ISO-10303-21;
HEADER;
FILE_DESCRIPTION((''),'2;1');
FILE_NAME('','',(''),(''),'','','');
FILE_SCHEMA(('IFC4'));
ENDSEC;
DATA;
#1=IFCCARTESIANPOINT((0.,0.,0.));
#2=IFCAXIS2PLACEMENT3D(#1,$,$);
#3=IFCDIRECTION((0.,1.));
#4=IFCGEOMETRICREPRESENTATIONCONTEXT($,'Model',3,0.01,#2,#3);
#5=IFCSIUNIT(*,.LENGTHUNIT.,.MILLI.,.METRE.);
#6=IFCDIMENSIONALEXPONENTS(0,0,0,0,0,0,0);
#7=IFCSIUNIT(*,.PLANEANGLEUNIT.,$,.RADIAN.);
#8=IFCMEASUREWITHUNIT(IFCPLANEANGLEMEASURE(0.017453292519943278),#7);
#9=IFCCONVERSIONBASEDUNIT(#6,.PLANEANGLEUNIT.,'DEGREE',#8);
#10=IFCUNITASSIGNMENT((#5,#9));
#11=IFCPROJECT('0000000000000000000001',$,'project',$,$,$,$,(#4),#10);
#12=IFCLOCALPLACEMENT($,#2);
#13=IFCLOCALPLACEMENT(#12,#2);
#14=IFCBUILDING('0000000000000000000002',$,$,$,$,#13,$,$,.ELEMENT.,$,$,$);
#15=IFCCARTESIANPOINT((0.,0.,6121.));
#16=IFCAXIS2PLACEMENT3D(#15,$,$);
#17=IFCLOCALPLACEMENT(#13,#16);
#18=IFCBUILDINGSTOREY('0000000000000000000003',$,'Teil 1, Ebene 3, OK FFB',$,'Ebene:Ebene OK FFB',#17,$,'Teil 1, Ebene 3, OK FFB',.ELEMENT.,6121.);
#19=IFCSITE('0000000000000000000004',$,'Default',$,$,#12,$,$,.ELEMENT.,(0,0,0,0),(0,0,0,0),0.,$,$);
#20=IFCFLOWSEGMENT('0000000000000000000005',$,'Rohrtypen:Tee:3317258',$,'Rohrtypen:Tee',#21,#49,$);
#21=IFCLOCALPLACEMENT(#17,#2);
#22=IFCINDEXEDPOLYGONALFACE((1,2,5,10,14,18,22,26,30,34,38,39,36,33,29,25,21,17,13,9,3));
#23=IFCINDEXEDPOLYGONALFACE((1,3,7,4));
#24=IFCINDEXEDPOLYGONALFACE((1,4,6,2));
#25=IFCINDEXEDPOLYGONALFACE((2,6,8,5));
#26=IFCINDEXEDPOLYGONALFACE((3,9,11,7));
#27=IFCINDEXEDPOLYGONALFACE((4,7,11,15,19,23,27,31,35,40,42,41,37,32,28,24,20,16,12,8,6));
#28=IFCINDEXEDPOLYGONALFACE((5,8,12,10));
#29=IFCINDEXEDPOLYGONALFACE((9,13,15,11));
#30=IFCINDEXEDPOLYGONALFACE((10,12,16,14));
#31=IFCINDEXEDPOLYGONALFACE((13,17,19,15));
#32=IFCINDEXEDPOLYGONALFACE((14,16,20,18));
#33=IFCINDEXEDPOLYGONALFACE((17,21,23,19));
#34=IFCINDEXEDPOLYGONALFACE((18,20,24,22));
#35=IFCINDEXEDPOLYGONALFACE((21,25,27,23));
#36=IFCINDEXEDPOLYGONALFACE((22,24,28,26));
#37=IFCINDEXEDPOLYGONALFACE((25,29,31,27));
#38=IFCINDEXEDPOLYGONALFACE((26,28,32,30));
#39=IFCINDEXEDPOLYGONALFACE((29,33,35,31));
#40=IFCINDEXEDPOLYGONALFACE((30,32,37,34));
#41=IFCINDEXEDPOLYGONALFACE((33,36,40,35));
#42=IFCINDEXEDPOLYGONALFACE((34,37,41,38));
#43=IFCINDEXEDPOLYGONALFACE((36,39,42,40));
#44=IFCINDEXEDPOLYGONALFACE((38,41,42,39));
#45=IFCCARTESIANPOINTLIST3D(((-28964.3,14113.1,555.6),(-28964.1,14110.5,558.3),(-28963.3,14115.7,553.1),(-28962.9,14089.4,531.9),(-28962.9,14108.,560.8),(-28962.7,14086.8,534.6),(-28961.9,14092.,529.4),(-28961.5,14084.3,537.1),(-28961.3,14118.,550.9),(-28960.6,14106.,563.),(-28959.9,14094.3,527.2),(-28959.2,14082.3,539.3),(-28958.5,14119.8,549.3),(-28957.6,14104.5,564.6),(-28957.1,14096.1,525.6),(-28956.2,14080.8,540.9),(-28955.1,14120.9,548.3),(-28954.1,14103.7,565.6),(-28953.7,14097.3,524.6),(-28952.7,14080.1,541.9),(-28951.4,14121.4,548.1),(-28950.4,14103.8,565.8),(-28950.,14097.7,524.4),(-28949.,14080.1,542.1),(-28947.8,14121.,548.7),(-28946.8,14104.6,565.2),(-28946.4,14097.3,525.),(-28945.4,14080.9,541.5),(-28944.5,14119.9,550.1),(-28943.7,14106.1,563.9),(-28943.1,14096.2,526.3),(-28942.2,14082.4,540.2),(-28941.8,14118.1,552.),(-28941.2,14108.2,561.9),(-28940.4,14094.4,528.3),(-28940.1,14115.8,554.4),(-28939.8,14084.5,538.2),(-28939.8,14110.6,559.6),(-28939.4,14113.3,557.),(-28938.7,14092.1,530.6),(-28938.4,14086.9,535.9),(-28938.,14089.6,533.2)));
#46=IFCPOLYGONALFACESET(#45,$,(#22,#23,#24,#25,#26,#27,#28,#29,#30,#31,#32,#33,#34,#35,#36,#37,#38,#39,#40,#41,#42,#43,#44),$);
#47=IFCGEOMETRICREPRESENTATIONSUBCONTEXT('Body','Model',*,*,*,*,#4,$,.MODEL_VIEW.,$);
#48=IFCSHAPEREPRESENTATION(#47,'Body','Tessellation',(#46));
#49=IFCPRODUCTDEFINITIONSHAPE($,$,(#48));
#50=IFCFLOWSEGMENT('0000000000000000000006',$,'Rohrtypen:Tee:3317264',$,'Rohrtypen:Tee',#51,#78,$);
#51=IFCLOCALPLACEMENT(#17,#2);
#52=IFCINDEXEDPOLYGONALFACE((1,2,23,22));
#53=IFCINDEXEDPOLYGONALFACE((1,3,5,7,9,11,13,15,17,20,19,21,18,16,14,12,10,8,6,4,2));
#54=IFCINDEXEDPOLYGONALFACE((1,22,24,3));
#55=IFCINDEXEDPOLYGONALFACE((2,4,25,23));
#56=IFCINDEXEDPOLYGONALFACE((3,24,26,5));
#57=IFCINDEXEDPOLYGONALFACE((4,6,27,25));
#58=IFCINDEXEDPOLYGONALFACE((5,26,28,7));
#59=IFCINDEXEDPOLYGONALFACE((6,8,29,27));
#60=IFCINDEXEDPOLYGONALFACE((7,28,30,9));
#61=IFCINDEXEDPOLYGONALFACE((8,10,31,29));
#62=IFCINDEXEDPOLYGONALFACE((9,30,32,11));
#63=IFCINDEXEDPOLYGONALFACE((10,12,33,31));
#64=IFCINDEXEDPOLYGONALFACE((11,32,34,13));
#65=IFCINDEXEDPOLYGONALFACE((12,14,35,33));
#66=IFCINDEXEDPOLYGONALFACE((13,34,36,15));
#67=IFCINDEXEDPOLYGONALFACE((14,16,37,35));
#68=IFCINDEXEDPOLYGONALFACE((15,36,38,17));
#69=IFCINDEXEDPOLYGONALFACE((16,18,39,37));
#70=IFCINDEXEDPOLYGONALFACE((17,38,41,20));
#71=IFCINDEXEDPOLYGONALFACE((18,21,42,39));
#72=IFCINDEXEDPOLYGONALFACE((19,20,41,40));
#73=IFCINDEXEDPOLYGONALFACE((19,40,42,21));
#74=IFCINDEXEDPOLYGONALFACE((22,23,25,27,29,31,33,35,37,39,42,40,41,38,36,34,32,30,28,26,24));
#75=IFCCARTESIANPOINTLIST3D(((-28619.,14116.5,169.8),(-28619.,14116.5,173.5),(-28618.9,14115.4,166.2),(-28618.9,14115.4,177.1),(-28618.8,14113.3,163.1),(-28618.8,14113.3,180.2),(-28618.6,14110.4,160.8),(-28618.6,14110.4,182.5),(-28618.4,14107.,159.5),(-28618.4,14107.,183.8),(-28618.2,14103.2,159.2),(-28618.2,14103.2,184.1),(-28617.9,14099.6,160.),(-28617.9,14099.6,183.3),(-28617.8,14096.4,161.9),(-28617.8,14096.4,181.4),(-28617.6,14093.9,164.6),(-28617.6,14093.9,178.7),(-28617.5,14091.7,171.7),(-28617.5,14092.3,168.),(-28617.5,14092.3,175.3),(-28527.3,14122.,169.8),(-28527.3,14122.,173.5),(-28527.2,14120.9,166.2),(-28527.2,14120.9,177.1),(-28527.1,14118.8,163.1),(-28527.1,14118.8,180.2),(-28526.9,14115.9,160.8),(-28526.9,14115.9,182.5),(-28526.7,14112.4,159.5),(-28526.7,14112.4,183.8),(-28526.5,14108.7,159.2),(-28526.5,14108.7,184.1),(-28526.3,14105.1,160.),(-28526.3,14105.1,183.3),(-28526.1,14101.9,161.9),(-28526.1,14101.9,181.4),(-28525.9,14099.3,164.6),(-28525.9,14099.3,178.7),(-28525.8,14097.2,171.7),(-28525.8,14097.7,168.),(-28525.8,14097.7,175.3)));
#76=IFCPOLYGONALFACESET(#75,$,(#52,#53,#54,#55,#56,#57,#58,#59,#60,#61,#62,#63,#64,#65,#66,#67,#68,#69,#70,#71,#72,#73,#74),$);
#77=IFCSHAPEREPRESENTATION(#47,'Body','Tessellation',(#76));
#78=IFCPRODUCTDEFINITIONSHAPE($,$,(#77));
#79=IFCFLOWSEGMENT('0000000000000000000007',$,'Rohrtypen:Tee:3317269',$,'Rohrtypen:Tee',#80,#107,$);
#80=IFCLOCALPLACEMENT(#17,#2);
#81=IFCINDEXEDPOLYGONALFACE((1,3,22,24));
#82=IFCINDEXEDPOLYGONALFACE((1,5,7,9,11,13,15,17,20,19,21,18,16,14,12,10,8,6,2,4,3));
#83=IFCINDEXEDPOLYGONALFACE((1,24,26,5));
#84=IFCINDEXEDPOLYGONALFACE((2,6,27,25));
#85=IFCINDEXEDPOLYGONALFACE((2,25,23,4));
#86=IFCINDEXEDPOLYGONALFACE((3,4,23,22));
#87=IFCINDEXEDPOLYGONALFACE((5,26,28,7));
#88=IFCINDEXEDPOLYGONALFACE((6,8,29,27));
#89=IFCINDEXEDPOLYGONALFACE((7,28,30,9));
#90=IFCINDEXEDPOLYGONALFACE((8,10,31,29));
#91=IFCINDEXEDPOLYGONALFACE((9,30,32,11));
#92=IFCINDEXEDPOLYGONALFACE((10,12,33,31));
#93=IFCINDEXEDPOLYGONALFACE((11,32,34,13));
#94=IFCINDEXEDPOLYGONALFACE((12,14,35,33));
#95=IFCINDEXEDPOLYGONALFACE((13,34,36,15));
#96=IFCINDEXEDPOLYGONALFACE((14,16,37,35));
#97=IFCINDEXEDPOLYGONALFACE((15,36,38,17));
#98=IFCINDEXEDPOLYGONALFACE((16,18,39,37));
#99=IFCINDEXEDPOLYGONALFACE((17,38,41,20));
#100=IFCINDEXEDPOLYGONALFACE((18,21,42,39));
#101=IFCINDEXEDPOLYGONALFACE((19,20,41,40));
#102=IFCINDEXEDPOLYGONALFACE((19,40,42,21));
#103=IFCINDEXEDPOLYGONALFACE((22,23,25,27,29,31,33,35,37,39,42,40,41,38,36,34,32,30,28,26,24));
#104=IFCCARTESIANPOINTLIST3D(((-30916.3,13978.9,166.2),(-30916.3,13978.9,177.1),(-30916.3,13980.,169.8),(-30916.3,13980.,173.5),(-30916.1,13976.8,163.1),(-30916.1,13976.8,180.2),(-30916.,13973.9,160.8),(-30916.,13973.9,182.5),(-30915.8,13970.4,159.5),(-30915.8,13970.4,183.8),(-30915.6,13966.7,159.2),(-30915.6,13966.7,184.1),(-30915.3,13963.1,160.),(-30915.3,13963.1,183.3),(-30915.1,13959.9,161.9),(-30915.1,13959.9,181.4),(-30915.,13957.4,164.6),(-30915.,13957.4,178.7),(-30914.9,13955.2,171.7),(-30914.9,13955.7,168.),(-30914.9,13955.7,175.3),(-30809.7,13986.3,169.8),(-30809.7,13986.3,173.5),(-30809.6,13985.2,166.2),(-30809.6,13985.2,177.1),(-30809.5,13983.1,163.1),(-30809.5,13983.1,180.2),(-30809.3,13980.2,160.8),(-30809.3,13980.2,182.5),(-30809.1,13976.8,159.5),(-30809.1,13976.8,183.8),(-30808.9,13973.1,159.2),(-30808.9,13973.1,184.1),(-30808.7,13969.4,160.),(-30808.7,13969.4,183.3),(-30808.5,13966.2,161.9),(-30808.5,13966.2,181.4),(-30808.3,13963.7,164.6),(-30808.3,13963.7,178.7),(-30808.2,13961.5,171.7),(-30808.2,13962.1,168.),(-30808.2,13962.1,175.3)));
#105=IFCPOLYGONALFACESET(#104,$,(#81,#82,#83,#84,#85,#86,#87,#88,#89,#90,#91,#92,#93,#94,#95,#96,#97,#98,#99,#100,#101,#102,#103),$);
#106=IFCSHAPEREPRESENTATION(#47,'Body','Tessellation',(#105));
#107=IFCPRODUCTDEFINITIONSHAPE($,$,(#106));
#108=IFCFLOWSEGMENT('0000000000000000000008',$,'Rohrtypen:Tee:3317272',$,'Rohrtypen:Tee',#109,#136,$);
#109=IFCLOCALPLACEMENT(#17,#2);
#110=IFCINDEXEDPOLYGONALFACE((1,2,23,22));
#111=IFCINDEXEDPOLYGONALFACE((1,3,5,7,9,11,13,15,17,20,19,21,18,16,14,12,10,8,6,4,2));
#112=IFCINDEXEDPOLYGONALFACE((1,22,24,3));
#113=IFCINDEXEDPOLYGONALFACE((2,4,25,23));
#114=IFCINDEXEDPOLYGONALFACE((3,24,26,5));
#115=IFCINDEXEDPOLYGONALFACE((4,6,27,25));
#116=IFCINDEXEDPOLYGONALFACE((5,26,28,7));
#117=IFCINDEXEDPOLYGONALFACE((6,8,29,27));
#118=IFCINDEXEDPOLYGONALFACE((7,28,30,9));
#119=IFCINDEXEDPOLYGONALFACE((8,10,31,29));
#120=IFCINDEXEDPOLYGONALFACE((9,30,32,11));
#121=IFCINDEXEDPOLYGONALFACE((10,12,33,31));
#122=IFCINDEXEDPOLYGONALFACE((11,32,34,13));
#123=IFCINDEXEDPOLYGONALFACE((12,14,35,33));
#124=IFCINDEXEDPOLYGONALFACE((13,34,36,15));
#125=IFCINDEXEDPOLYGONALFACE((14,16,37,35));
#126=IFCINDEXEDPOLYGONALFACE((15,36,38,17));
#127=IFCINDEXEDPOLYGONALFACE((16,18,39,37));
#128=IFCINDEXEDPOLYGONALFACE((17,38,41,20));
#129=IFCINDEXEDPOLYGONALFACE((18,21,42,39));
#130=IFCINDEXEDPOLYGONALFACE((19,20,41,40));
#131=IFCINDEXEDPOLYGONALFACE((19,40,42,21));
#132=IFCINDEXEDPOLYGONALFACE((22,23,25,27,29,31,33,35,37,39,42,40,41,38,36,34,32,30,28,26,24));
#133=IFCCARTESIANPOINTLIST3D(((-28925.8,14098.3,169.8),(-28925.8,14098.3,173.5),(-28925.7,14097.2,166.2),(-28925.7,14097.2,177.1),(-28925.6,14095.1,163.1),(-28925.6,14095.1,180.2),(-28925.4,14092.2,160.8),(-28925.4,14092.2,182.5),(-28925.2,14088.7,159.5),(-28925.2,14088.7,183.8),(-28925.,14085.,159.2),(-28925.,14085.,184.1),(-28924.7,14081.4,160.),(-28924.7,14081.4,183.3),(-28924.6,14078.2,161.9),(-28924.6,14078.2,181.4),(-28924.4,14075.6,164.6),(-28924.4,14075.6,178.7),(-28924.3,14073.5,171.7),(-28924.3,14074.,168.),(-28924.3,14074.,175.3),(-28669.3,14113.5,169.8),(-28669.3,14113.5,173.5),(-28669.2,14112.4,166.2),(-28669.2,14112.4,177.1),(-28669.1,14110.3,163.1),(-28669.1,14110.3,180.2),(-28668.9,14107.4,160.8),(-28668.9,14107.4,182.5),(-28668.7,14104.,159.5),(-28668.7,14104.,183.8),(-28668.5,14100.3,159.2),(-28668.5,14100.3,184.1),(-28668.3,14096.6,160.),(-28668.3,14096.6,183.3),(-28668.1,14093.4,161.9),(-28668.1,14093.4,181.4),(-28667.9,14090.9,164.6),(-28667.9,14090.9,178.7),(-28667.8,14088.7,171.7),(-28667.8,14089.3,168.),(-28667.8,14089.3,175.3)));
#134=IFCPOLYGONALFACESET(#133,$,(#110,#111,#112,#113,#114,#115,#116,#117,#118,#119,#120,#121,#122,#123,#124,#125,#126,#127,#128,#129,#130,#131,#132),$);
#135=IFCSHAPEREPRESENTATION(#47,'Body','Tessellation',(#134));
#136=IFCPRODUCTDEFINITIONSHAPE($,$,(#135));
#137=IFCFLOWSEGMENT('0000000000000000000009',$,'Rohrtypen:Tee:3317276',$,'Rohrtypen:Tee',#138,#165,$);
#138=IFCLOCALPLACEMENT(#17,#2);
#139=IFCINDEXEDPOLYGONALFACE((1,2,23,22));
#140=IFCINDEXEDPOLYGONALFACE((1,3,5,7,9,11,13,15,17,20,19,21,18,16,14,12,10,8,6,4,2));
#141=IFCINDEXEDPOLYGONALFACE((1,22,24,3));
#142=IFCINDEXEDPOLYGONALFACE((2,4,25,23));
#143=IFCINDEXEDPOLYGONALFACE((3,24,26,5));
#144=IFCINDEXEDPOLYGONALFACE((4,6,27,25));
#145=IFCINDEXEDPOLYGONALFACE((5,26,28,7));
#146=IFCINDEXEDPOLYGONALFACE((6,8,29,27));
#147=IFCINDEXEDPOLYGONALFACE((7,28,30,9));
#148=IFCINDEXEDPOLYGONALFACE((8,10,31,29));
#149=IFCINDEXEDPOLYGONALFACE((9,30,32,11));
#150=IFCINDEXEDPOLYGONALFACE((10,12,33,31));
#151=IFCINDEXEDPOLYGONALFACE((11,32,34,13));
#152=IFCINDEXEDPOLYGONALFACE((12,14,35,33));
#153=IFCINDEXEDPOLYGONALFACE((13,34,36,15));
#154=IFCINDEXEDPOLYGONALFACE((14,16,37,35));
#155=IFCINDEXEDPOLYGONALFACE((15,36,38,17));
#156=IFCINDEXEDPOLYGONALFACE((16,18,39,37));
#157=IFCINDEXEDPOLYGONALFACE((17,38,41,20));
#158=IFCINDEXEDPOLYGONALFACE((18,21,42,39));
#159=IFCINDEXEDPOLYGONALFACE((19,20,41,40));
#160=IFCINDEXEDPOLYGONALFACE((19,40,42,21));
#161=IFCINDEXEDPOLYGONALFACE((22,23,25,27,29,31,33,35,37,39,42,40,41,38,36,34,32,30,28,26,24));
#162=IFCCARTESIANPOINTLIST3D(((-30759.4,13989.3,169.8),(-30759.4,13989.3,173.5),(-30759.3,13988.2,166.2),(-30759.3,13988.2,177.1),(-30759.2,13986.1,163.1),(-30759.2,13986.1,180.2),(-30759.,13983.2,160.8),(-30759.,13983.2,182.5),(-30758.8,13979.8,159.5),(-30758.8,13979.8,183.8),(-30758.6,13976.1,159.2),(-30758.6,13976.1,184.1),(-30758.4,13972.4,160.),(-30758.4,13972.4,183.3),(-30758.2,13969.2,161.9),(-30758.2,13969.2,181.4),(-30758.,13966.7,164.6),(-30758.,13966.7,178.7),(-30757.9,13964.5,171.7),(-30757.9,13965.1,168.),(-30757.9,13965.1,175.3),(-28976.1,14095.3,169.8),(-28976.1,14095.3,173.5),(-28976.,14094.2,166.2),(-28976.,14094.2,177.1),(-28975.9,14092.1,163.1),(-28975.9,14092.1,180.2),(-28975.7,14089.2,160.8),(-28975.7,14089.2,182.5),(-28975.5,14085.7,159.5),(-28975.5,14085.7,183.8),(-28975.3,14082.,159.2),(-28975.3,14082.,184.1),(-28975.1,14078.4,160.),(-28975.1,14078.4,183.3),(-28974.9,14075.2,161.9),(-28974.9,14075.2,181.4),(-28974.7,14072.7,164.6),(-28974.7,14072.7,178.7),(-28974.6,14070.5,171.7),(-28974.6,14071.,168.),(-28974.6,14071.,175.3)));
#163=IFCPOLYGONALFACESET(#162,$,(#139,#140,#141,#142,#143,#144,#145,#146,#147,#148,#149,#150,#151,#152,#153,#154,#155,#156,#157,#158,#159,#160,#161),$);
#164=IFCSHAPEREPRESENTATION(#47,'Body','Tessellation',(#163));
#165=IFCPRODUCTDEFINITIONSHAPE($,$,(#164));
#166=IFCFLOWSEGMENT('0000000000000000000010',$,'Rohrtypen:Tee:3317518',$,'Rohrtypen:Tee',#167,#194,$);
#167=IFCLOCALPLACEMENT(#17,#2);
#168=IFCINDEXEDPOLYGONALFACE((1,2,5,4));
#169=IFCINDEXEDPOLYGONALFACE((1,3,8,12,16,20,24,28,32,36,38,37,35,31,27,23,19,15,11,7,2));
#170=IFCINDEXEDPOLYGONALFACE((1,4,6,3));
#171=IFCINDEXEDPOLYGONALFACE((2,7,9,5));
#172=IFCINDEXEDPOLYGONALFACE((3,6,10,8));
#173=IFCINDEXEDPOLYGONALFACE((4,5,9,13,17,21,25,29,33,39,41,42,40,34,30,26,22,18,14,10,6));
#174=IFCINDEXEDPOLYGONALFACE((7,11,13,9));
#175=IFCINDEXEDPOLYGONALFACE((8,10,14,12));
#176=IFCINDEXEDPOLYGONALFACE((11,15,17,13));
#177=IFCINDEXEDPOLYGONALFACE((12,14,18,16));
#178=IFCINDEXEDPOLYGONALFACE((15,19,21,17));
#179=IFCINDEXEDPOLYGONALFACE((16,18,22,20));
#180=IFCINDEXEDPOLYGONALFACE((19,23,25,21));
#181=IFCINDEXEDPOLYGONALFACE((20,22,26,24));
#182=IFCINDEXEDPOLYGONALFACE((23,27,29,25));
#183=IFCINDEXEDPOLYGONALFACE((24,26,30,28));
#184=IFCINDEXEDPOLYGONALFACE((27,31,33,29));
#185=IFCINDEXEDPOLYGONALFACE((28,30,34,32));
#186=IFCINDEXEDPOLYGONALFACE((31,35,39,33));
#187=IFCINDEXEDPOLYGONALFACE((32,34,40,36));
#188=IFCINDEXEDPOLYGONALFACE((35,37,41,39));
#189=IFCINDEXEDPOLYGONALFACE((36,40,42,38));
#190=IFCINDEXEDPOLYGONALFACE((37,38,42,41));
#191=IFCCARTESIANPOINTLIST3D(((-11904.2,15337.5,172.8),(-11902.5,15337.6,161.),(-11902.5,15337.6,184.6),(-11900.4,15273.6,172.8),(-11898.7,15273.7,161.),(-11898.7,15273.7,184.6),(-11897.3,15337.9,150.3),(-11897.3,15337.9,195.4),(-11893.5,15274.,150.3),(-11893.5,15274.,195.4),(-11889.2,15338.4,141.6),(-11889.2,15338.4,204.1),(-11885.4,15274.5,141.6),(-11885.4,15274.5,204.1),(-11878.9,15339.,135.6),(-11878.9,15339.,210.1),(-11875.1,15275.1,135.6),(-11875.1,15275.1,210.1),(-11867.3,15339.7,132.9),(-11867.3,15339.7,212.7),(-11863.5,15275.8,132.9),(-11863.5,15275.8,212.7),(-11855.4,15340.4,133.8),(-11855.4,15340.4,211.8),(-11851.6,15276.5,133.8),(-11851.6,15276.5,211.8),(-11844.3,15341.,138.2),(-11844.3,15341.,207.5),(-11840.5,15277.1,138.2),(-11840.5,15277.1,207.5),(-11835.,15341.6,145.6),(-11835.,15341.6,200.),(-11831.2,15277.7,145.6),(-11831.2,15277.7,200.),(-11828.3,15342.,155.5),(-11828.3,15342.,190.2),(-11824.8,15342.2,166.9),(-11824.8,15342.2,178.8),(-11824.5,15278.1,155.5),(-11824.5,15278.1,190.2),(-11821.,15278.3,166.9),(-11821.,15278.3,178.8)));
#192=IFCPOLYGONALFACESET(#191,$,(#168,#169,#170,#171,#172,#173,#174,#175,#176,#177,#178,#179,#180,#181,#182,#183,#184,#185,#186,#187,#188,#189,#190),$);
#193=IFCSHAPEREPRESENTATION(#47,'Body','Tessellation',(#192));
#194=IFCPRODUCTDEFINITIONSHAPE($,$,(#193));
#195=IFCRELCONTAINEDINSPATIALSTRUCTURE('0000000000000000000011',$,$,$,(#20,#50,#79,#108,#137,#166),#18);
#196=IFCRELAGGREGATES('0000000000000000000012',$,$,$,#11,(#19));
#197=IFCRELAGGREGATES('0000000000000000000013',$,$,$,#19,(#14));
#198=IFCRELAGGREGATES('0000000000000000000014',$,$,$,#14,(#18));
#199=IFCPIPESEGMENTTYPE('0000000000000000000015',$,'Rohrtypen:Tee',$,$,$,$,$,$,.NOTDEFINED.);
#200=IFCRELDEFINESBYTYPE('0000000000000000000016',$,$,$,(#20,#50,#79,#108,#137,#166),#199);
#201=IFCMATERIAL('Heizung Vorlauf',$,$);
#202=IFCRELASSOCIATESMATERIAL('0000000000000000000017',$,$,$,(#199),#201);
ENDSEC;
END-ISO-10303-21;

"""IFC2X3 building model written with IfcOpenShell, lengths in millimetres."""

from ifc_helpers import new_model, entity, si_unit, converted_unit, direction, frame, frame_2d, origin, origin_2d_with_axis, place, context, subcontext, project, spatial, circle, extrude, material, type_object, element, save


model = new_model("IFC2X3")

# Units and contexts
model_context = context("Model", 3, precision=0.01, world=origin(), true_north=direction((0.0, 1.0)))
body_context = subcontext(model_context, "Body", "Model", "MODEL_VIEW")
ifc_project = project(units=[si_unit("LENGTHUNIT", "METRE", prefix="MILLI"), converted_unit("PLANEANGLEUNIT", "DEGREE", entity("IfcPlaneAngleMeasure", 0.017453292519943278), si_unit("PLANEANGLEUNIT", "RADIAN"), dimensions=[0, 0, 0, 0, 0, 0, 0])], contexts=[model_context])

# Site, building, storey
site_placement = place(None, origin())
site = spatial("IfcSite", under=ifc_project, at=site_placement, Name="Default", CompositionType="ELEMENT", RefLatitude=(0, 0, 0, 0), RefLongitude=(0, 0, 0, 0), RefElevation=0.0)
building_placement = place(site_placement, origin())
building = spatial("IfcBuilding", under=site, at=building_placement, CompositionType="ELEMENT")
storey_placement = place(building_placement, frame((0.0, 0.0, 6121.0)))
storey = spatial("IfcBuildingStorey", under=building, at=storey_placement, Name="Teil 1, Ebene 3, OK FFB", ObjectType="Ebene:Ebene OK FFB", LongName="Teil 1, Ebene 3, OK FFB", CompositionType="ELEMENT", Elevation=6121.0)

# Flow segments
ifc_material = material(Name="Heizung Vorlauf")
pipe_segment_type = type_object("IfcPipeSegmentType", Name="Rohrtypen:Tee", PredefinedType="NOTDEFINED", material=ifc_material)
flow_segment_1_placement = place(storey_placement, origin())
element("IfcFlowSegment", 1, at=flow_segment_1_placement, inside=storey, type_object=pipe_segment_type, Name="Rohrtypen:Tee:3317258", ObjectType="Rohrtypen:Tee", context=body_context, shape_type="SweptSolid", body=[
    extrude(circle(Radius=12.5, at=origin_2d_with_axis()), frame((-28950.4, 14088.8, 533.2), z_axis=(-0.041945, 0.705862, 0.707107), x_axis=(0.998239, 0.059319, 0.0)), (0.0, 0.0, 1.0), 33.5),
])
flow_segment_2_placement = place(storey_placement, origin())
element("IfcFlowSegment", 2, at=flow_segment_2_placement, inside=storey, type_object=pipe_segment_type, Name="Rohrtypen:Tee:3317264", ObjectType="Rohrtypen:Tee", context=body_context, shape_type="SweptSolid", body=[
    extrude(circle(Radius=12.5, at=frame_2d((0.0, 0.0), x_axis=(1.0, 0.0))), frame((-28618.2, 14104.2, 171.7), z_axis=(0.998239, 0.059319, 0.0), x_axis=(0.059319, -0.998239, 0.0)), (0.0, 0.0, 1.0), 91.9),
])
flow_segment_3_placement = place(storey_placement, origin())
element("IfcFlowSegment", 3, at=flow_segment_3_placement, inside=storey, type_object=pipe_segment_type, Name="Rohrtypen:Tee:3317269", ObjectType="Rohrtypen:Tee", context=body_context, shape_type="SweptSolid", body=[
    extrude(circle(Radius=12.5, at=origin_2d_with_axis()), frame((-30915.6, 13967.7, 171.7), z_axis=(0.998239, 0.059319, 0.0), x_axis=(0.059319, -0.998239, 0.0)), (0.0, 0.0, 1.0), 106.9),
])
flow_segment_4_placement = place(storey_placement, origin())
element("IfcFlowSegment", 4, at=flow_segment_4_placement, inside=storey, type_object=pipe_segment_type, Name="Rohrtypen:Tee:3317272", ObjectType="Rohrtypen:Tee", context=body_context, shape_type="SweptSolid", body=[
    extrude(circle(Radius=12.5, at=frame_2d((0.0, 0.0), x_axis=(1.0, 0.0))), frame((-28925.0, 14085.9, 171.7), z_axis=(0.998239, 0.059319, 0.0), x_axis=(0.059319, -0.998239, 0.0)), (0.0, 0.0, 1.0), 256.9),
])
flow_segment_5_placement = place(storey_placement, origin())
element("IfcFlowSegment", 5, at=flow_segment_5_placement, inside=storey, type_object=pipe_segment_type, Name="Rohrtypen:Tee:3317276", ObjectType="Rohrtypen:Tee", context=body_context, shape_type="SweptSolid", body=[
    extrude(circle(Radius=12.5, at=frame_2d((0.0, 0.0), x_axis=(1.0, 0.0))), frame((-30758.6, 13977.0, 171.7), z_axis=(0.998239, 0.059319, 0.0), x_axis=(0.059319, -0.998239, 0.0)), (0.0, 0.0, 1.0), 1786.4),
])
flow_segment_6_placement = place(storey_placement, origin())
element("IfcFlowSegment", 6, at=flow_segment_6_placement, inside=storey, type_object=pipe_segment_type, Name="Rohrtypen:Tee:3317518", ObjectType="Rohrtypen:Tee", context=body_context, shape_type="SweptSolid", body=[
    extrude(circle(Radius=40.0, at=origin_2d_with_axis()), frame((-11864.3, 15339.8, 172.8), z_axis=(0.059319, -0.998239, 0.0), x_axis=(-0.998239, -0.059319, 0.0)), (0.0, 0.0, 1.0), 64.0),
])

save(model, "model.ifc")
